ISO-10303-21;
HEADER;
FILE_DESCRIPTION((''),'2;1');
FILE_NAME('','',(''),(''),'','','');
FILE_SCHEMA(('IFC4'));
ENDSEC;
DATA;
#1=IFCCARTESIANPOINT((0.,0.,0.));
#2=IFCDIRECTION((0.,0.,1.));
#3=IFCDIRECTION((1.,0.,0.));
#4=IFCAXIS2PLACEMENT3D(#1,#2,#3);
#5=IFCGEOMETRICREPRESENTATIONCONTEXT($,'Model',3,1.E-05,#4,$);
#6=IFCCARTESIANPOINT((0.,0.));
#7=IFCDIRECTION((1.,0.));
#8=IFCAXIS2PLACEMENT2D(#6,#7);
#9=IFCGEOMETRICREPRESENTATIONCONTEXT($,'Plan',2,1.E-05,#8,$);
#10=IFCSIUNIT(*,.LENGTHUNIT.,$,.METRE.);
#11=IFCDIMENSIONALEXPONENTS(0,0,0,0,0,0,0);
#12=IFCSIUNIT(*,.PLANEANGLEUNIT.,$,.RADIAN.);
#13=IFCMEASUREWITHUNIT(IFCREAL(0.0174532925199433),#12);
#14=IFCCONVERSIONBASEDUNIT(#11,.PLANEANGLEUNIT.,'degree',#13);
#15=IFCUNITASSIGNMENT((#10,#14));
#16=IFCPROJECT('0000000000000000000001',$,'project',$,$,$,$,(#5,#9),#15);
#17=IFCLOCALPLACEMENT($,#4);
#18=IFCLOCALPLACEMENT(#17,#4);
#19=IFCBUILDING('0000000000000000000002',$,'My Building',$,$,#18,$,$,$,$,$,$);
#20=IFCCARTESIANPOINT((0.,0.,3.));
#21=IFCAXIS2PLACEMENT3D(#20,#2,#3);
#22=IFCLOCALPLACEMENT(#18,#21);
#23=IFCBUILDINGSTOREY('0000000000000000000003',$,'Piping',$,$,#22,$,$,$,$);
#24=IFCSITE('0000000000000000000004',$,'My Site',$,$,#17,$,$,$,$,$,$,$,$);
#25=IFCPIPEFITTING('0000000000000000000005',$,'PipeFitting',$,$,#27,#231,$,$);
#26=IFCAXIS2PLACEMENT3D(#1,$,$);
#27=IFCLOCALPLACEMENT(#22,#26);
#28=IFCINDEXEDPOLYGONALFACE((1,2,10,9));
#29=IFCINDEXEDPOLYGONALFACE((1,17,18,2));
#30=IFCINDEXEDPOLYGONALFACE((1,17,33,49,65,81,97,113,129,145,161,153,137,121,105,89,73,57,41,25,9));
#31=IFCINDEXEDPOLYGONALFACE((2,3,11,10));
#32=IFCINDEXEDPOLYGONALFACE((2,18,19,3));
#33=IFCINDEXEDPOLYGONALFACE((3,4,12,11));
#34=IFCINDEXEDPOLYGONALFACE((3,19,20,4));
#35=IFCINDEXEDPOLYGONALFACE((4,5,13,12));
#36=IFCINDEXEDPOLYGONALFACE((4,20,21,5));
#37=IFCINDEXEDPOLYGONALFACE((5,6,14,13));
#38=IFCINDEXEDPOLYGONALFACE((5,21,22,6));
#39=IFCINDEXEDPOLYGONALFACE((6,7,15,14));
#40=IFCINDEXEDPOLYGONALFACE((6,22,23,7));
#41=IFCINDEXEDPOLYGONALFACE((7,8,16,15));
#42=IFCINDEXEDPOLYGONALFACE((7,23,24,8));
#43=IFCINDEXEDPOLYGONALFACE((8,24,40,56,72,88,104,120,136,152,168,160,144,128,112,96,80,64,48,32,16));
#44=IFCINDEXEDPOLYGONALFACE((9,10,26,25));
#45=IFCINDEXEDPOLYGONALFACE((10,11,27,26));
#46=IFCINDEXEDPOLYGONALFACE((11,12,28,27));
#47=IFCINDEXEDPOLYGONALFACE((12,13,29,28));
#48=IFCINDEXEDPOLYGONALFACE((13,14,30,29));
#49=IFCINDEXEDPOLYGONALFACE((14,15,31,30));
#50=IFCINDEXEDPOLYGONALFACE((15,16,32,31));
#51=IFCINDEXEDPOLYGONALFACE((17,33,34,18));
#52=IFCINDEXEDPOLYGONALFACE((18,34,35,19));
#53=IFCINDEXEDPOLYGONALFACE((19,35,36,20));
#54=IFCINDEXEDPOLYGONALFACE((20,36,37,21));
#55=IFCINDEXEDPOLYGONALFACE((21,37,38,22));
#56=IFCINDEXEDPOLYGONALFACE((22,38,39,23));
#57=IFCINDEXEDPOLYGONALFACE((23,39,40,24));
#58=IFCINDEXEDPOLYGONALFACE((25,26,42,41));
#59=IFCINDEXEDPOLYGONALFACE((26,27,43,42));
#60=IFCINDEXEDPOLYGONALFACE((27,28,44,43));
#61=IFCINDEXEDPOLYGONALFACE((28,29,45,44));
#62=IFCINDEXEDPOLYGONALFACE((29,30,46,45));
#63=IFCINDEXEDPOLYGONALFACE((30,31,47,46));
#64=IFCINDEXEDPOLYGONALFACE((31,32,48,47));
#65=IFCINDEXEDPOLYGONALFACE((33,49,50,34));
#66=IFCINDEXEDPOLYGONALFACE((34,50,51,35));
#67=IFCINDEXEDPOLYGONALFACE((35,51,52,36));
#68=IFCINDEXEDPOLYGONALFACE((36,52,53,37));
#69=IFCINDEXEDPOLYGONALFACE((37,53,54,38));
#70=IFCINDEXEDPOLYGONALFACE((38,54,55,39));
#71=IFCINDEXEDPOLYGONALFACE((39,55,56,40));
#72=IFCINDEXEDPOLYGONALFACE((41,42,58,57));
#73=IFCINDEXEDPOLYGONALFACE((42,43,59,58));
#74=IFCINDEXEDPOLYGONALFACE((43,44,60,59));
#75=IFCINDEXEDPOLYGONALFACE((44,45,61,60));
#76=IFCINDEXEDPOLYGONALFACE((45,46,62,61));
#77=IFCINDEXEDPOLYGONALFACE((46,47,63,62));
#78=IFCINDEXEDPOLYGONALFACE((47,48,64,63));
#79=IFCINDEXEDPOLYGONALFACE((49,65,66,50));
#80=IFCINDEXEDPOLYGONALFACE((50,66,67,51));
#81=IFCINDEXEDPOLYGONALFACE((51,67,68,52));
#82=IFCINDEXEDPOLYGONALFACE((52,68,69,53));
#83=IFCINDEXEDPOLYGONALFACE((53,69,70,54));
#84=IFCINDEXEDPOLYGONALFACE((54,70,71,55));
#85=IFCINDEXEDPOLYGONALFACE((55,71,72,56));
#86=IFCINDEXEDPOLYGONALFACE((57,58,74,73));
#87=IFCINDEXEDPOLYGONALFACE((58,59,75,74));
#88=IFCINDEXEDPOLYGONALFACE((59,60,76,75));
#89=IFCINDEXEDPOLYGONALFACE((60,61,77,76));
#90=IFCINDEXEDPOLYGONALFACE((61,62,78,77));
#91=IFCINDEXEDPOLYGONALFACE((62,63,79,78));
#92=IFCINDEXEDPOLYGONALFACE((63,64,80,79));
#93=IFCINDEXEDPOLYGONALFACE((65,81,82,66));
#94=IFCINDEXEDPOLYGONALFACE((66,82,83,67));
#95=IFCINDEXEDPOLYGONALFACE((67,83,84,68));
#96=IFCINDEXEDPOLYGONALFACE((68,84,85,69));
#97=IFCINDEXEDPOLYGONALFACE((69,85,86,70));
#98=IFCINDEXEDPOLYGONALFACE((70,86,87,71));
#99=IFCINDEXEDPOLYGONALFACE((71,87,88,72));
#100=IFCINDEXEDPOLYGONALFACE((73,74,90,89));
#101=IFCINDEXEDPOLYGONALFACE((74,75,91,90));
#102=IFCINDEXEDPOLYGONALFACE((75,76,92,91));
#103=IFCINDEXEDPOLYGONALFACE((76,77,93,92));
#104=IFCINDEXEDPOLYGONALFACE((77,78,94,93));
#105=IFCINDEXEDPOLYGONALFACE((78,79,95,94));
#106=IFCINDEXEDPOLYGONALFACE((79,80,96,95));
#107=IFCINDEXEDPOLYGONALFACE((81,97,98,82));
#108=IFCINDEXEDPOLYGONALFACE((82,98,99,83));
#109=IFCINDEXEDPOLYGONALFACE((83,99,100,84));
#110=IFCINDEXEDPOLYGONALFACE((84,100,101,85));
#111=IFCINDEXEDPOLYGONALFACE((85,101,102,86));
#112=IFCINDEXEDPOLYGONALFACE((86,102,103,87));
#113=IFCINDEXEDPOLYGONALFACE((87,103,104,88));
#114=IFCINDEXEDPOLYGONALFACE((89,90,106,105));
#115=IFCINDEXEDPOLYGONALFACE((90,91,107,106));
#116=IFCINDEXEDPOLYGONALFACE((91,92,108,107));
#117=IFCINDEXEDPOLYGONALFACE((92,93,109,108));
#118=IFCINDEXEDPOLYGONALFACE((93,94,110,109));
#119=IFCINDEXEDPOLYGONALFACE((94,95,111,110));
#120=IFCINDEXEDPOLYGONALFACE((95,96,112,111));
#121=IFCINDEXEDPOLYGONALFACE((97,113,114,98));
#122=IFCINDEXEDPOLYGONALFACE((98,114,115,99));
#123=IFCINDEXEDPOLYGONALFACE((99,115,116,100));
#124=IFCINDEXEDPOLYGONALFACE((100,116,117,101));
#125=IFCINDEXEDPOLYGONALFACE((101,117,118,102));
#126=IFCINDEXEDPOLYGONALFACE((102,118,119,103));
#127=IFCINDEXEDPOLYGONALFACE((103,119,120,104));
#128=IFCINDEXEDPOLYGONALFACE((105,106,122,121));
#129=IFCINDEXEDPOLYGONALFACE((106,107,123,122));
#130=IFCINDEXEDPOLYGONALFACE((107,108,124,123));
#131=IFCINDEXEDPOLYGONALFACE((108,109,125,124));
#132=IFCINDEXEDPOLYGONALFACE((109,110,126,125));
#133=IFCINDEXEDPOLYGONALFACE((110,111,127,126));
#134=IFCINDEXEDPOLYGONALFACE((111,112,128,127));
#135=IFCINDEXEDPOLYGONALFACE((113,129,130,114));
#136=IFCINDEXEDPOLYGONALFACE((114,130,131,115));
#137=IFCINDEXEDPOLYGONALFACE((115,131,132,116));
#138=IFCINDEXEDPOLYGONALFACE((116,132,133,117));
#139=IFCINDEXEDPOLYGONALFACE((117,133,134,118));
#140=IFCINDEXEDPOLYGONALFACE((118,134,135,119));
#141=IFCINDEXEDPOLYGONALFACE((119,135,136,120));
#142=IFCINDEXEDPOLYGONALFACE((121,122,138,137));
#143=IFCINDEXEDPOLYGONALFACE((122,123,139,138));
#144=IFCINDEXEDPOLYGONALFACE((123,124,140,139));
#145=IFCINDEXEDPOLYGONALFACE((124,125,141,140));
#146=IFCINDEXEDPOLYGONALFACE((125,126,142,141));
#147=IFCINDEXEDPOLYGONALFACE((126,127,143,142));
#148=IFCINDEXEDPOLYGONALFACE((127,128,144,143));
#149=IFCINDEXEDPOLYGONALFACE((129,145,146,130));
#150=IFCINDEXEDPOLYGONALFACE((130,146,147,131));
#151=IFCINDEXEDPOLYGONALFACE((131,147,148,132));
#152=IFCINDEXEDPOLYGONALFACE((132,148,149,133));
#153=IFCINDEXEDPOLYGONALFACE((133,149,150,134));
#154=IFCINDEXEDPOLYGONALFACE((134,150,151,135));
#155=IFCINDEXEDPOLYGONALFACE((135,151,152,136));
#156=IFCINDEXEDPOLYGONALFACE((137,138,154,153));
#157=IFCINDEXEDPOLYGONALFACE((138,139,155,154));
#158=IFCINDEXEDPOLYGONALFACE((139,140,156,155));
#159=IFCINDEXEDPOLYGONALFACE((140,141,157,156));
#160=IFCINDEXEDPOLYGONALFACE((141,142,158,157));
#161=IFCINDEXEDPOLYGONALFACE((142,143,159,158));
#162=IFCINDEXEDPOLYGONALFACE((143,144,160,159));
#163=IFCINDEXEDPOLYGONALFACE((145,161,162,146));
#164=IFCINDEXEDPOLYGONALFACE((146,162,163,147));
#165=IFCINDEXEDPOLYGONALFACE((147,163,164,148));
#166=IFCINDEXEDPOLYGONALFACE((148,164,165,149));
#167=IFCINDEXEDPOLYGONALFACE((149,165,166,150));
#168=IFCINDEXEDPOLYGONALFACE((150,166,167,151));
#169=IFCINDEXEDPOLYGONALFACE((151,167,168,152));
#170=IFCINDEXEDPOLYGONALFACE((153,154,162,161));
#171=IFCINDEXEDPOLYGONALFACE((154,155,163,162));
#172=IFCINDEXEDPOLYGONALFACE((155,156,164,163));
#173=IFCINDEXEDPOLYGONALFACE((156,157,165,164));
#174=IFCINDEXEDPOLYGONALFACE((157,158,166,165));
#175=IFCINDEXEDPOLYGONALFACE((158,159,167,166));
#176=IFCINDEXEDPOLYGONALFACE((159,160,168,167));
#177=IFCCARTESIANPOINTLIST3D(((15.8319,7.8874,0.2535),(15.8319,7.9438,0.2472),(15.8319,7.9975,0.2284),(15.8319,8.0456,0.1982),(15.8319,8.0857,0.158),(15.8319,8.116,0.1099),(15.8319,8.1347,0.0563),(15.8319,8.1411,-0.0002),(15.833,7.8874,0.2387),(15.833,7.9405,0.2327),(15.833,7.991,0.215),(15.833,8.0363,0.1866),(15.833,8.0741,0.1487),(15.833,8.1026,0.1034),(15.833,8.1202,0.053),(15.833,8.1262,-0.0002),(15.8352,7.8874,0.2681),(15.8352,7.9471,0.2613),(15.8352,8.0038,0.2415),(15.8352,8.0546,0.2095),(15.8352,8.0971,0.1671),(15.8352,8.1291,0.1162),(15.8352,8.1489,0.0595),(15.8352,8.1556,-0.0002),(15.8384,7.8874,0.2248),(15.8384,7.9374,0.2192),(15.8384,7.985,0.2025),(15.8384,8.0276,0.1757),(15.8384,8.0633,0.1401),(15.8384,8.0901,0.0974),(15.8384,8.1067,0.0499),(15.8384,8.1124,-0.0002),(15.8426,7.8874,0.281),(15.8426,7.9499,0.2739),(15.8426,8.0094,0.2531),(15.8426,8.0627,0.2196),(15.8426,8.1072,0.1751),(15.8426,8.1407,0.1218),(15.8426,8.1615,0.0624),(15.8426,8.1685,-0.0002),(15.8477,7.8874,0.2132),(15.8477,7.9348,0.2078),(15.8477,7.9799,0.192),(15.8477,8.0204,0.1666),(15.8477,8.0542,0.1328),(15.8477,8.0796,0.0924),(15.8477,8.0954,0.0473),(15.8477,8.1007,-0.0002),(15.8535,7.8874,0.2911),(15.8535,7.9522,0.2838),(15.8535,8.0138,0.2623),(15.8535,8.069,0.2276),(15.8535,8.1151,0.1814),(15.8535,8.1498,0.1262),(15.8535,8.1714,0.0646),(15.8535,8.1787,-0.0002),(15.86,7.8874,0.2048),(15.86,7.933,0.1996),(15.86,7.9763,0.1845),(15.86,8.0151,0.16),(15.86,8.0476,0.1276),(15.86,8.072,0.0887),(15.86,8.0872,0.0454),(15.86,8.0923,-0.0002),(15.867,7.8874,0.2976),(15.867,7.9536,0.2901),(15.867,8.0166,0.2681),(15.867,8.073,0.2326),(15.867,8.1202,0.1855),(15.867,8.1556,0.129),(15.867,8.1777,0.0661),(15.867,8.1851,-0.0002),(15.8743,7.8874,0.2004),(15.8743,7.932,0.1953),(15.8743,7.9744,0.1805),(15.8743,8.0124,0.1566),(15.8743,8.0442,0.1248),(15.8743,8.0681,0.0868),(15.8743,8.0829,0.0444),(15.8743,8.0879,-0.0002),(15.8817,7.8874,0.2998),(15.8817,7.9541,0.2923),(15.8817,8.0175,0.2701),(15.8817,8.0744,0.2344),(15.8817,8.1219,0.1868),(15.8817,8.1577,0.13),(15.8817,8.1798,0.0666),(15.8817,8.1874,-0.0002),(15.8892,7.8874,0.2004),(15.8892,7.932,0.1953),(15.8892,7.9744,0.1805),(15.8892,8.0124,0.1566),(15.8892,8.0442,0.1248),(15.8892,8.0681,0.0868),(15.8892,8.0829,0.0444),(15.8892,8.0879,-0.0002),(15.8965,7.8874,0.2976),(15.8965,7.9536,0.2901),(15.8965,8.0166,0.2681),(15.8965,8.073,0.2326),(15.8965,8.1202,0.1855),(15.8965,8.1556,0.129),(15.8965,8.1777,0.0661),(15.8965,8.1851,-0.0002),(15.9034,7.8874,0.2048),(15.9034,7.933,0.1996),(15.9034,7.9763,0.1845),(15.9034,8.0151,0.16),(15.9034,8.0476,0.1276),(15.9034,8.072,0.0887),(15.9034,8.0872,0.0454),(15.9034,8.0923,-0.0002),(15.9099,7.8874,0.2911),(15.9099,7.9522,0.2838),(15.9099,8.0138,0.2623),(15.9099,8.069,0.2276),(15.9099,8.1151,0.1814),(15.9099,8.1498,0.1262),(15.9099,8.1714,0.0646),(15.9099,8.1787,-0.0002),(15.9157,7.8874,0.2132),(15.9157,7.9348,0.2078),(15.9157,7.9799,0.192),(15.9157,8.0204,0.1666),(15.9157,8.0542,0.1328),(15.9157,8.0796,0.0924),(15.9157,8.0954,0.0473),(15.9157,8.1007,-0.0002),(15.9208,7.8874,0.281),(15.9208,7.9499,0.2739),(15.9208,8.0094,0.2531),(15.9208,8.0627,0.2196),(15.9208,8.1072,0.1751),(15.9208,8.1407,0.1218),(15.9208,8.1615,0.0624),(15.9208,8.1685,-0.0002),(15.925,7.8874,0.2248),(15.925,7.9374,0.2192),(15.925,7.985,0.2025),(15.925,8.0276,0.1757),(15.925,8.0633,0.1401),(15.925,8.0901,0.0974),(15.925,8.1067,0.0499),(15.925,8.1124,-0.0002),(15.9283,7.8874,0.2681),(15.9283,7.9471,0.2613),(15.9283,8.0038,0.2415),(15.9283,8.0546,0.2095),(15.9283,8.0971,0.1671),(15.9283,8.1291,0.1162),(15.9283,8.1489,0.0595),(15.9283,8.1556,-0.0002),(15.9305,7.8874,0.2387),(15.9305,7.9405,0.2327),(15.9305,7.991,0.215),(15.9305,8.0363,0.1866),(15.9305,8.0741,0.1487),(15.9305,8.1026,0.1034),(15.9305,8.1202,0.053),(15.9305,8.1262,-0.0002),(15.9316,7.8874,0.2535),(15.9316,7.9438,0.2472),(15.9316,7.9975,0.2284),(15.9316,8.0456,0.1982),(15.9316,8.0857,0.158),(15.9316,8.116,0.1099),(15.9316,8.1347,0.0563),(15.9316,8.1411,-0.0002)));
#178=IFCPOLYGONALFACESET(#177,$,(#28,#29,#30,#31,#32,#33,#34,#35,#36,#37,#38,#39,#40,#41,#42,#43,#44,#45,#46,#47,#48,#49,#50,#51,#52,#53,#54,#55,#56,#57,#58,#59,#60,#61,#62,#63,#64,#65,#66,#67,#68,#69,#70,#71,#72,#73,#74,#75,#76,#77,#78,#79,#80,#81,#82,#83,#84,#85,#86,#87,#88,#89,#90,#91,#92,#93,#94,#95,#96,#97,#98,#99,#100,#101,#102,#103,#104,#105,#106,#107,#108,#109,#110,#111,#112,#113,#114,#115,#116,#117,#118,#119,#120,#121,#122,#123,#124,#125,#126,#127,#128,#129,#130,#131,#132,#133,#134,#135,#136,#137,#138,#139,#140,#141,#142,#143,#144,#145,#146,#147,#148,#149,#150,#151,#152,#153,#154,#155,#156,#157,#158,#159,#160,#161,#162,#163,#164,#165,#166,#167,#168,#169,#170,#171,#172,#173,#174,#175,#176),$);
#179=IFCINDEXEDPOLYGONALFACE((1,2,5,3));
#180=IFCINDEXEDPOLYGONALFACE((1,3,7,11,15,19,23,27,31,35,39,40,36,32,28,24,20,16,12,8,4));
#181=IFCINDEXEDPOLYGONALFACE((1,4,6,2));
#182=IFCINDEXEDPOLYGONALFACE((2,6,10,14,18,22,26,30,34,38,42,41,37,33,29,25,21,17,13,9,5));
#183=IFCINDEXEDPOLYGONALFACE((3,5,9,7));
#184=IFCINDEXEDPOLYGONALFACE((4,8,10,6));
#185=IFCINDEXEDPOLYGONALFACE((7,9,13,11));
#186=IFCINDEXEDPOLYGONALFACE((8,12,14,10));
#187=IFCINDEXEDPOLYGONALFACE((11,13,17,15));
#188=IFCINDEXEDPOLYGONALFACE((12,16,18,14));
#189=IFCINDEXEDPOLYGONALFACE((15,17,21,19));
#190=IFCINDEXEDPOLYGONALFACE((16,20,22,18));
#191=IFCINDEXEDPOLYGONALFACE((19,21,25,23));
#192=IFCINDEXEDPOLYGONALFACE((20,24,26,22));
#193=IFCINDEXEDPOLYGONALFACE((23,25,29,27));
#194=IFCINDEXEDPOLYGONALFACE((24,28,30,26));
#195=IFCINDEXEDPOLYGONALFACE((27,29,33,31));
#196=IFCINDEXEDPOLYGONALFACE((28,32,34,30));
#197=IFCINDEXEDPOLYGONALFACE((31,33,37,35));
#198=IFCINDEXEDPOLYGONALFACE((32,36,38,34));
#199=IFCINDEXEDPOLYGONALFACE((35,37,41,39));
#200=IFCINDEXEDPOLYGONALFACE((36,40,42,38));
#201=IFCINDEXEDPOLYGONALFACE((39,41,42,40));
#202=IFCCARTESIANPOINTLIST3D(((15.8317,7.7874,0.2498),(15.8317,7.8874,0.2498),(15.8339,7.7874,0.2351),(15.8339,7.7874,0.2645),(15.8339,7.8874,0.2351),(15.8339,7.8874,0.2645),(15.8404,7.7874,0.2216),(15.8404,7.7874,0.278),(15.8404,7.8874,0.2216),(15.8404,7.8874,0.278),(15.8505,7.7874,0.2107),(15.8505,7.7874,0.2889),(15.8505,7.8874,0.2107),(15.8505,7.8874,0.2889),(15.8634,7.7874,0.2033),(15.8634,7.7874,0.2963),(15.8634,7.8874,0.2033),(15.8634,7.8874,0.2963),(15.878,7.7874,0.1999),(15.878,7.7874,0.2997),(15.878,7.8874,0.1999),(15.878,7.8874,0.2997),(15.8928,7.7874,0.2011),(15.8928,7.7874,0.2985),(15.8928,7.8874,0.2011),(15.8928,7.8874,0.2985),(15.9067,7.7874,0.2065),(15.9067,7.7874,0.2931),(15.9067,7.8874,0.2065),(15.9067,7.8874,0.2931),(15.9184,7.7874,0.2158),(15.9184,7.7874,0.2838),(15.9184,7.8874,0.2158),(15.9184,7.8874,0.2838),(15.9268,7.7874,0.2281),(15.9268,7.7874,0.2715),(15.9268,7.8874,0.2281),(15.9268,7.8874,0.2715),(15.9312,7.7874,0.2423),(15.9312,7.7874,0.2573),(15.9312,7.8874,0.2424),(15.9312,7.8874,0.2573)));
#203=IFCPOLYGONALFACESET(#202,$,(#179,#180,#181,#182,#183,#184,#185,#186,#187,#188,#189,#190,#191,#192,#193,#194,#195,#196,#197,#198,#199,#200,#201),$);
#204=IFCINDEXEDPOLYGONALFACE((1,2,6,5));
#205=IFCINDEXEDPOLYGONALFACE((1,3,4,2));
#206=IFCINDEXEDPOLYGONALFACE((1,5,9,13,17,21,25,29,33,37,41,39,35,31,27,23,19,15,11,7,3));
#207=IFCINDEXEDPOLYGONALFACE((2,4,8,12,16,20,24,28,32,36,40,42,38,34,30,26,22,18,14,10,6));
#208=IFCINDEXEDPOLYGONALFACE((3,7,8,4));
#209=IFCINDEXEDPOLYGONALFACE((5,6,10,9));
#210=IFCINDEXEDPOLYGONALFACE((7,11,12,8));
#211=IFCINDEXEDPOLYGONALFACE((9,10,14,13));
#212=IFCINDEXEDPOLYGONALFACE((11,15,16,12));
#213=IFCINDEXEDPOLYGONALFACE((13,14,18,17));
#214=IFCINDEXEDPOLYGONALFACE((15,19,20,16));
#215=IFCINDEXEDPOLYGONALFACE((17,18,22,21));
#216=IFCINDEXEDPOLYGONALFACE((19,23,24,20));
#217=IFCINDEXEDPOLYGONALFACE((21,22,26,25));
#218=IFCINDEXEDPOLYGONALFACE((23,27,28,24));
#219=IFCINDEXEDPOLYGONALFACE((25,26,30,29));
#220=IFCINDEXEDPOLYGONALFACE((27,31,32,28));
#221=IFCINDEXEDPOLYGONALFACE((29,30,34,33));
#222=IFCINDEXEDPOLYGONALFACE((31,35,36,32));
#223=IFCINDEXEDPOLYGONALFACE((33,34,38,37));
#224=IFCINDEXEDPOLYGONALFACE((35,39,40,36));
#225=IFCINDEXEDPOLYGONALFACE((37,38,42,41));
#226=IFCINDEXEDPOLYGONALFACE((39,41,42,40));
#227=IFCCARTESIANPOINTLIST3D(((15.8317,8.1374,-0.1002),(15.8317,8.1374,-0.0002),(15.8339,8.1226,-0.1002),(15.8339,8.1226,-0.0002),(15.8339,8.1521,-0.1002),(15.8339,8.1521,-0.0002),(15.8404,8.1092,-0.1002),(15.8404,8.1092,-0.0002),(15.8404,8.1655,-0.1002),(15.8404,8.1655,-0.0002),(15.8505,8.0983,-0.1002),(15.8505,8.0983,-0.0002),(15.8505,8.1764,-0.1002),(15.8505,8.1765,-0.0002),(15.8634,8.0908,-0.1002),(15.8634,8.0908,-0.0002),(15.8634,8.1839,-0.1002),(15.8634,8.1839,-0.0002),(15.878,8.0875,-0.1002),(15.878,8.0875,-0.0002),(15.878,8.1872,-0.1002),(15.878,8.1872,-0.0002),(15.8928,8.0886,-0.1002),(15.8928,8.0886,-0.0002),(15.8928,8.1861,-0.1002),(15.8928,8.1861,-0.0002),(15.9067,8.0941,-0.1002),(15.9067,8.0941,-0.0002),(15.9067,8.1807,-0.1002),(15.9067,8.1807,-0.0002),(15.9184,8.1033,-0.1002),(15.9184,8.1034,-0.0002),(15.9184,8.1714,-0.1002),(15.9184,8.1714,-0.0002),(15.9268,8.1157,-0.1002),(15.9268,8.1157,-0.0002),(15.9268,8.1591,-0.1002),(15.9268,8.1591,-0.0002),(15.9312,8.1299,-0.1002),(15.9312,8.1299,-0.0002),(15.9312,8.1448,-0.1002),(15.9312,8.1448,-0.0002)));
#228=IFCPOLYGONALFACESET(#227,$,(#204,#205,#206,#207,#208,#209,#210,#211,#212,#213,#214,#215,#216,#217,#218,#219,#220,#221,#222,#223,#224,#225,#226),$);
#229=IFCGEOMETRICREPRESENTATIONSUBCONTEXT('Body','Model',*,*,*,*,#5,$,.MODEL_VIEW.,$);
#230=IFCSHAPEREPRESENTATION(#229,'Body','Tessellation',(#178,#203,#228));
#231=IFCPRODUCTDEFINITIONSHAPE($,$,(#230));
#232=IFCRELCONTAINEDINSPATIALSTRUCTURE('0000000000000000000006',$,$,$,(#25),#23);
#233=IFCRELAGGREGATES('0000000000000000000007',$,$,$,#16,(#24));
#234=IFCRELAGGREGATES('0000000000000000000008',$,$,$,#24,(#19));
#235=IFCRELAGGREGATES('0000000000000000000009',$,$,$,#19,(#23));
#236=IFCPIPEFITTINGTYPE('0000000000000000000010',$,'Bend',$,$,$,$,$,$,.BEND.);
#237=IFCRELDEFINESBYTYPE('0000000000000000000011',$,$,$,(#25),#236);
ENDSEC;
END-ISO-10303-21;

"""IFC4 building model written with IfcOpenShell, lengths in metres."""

from ifc_helpers import new_model, entity, si_unit, converted_unit, frame, origin_with_axes, origin_2d_with_axis, place, context, subcontext, project, spatial, circle, extrude, source, transform, mapped, type_object, type_shapes, element, save


model = new_model("IFC4")

# Units and contexts
model_context = context("Model", 3, precision=1e-05, world=origin_with_axes())
plan_context = context("Plan", 2, precision=1e-05, world=origin_2d_with_axis())
body_context = subcontext(model_context, "Body", "Model", "MODEL_VIEW")
ifc_project = project(units=[si_unit("LENGTHUNIT", "METRE"), converted_unit("PLANEANGLEUNIT", "degree", entity("IfcReal", 0.0174532925199433), si_unit("PLANEANGLEUNIT", "RADIAN"), dimensions=[0, 0, 0, 0, 0, 0, 0])], contexts=[model_context, plan_context])

# Site, building, storey
site_placement = place(None, origin_with_axes())
site = spatial("IfcSite", under=ifc_project, at=site_placement, Name="My Site")
building_placement = place(site_placement, origin_with_axes())
building = spatial("IfcBuilding", under=site, at=building_placement, Name="My Building")
storey_placement = place(building_placement, frame((0.0, 0.0, 3.0), z_axis=(0.0, 0.0, 1.0), x_axis=(1.0, 0.0, 0.0)))
storey = spatial("IfcBuildingStorey", under=building, at=storey_placement, Name="Piping")

# Pipe fitting
pipe_fitting_type_1 = type_object("IfcPipeFittingType", Name="Bend", PredefinedType="BEND")
shared_shape = source(origin_with_axes(), body_context, "Body", "SolidModel", [
    entity("IfcSweptDiskSolid", entity("IfcIndexedPolyCurve", entity("IfcCartesianPointList3D", [[0.0, 0.0, 0.1], [0.0, -0.0732, 0.2768], [0.0, -0.25, 0.35]]), [entity("IfcArcIndex", [1, 2, 3])]), 0.05),
    extrude(circle(Radius=0.05), origin_with_axes(), (0.0, 0.0, 1.0), 0.1),
    extrude(circle(Radius=0.05), frame((0.0, -0.25, 0.35), z_axis=(0.0, -1.0, -0.00003), x_axis=(1.0, 0.0, 0.0)), (0.0, 0.0, 1.0), 0.1),
])
type_shapes(pipe_fitting_type_1, [shared_shape])
for number, where, z_axis, x_axis, name in (
    (1, (15.8817, 7.7874, 0.2498), (0.0, 1.0, 0.000008), (-1.0, 0.0, 0.0), "PipeFitting"),
):
    element("IfcPipeFitting", number, at=place(storey_placement, frame(where, z_axis=z_axis, x_axis=x_axis)), inside=storey, type_object=pipe_fitting_type_1, Name=name, context=body_context, shape_type="MappedRepresentation", body=[
        mapped(shared_shape, transform((0.0, 0.0, 0.0), x_axis=(1.0, 0.0, 0.0), y_axis=(0.0, 1.0, 0.0), z_axis=(0.0, 0.0, 1.0), scale=1.0)),
    ])

save(model, "model.ifc")
